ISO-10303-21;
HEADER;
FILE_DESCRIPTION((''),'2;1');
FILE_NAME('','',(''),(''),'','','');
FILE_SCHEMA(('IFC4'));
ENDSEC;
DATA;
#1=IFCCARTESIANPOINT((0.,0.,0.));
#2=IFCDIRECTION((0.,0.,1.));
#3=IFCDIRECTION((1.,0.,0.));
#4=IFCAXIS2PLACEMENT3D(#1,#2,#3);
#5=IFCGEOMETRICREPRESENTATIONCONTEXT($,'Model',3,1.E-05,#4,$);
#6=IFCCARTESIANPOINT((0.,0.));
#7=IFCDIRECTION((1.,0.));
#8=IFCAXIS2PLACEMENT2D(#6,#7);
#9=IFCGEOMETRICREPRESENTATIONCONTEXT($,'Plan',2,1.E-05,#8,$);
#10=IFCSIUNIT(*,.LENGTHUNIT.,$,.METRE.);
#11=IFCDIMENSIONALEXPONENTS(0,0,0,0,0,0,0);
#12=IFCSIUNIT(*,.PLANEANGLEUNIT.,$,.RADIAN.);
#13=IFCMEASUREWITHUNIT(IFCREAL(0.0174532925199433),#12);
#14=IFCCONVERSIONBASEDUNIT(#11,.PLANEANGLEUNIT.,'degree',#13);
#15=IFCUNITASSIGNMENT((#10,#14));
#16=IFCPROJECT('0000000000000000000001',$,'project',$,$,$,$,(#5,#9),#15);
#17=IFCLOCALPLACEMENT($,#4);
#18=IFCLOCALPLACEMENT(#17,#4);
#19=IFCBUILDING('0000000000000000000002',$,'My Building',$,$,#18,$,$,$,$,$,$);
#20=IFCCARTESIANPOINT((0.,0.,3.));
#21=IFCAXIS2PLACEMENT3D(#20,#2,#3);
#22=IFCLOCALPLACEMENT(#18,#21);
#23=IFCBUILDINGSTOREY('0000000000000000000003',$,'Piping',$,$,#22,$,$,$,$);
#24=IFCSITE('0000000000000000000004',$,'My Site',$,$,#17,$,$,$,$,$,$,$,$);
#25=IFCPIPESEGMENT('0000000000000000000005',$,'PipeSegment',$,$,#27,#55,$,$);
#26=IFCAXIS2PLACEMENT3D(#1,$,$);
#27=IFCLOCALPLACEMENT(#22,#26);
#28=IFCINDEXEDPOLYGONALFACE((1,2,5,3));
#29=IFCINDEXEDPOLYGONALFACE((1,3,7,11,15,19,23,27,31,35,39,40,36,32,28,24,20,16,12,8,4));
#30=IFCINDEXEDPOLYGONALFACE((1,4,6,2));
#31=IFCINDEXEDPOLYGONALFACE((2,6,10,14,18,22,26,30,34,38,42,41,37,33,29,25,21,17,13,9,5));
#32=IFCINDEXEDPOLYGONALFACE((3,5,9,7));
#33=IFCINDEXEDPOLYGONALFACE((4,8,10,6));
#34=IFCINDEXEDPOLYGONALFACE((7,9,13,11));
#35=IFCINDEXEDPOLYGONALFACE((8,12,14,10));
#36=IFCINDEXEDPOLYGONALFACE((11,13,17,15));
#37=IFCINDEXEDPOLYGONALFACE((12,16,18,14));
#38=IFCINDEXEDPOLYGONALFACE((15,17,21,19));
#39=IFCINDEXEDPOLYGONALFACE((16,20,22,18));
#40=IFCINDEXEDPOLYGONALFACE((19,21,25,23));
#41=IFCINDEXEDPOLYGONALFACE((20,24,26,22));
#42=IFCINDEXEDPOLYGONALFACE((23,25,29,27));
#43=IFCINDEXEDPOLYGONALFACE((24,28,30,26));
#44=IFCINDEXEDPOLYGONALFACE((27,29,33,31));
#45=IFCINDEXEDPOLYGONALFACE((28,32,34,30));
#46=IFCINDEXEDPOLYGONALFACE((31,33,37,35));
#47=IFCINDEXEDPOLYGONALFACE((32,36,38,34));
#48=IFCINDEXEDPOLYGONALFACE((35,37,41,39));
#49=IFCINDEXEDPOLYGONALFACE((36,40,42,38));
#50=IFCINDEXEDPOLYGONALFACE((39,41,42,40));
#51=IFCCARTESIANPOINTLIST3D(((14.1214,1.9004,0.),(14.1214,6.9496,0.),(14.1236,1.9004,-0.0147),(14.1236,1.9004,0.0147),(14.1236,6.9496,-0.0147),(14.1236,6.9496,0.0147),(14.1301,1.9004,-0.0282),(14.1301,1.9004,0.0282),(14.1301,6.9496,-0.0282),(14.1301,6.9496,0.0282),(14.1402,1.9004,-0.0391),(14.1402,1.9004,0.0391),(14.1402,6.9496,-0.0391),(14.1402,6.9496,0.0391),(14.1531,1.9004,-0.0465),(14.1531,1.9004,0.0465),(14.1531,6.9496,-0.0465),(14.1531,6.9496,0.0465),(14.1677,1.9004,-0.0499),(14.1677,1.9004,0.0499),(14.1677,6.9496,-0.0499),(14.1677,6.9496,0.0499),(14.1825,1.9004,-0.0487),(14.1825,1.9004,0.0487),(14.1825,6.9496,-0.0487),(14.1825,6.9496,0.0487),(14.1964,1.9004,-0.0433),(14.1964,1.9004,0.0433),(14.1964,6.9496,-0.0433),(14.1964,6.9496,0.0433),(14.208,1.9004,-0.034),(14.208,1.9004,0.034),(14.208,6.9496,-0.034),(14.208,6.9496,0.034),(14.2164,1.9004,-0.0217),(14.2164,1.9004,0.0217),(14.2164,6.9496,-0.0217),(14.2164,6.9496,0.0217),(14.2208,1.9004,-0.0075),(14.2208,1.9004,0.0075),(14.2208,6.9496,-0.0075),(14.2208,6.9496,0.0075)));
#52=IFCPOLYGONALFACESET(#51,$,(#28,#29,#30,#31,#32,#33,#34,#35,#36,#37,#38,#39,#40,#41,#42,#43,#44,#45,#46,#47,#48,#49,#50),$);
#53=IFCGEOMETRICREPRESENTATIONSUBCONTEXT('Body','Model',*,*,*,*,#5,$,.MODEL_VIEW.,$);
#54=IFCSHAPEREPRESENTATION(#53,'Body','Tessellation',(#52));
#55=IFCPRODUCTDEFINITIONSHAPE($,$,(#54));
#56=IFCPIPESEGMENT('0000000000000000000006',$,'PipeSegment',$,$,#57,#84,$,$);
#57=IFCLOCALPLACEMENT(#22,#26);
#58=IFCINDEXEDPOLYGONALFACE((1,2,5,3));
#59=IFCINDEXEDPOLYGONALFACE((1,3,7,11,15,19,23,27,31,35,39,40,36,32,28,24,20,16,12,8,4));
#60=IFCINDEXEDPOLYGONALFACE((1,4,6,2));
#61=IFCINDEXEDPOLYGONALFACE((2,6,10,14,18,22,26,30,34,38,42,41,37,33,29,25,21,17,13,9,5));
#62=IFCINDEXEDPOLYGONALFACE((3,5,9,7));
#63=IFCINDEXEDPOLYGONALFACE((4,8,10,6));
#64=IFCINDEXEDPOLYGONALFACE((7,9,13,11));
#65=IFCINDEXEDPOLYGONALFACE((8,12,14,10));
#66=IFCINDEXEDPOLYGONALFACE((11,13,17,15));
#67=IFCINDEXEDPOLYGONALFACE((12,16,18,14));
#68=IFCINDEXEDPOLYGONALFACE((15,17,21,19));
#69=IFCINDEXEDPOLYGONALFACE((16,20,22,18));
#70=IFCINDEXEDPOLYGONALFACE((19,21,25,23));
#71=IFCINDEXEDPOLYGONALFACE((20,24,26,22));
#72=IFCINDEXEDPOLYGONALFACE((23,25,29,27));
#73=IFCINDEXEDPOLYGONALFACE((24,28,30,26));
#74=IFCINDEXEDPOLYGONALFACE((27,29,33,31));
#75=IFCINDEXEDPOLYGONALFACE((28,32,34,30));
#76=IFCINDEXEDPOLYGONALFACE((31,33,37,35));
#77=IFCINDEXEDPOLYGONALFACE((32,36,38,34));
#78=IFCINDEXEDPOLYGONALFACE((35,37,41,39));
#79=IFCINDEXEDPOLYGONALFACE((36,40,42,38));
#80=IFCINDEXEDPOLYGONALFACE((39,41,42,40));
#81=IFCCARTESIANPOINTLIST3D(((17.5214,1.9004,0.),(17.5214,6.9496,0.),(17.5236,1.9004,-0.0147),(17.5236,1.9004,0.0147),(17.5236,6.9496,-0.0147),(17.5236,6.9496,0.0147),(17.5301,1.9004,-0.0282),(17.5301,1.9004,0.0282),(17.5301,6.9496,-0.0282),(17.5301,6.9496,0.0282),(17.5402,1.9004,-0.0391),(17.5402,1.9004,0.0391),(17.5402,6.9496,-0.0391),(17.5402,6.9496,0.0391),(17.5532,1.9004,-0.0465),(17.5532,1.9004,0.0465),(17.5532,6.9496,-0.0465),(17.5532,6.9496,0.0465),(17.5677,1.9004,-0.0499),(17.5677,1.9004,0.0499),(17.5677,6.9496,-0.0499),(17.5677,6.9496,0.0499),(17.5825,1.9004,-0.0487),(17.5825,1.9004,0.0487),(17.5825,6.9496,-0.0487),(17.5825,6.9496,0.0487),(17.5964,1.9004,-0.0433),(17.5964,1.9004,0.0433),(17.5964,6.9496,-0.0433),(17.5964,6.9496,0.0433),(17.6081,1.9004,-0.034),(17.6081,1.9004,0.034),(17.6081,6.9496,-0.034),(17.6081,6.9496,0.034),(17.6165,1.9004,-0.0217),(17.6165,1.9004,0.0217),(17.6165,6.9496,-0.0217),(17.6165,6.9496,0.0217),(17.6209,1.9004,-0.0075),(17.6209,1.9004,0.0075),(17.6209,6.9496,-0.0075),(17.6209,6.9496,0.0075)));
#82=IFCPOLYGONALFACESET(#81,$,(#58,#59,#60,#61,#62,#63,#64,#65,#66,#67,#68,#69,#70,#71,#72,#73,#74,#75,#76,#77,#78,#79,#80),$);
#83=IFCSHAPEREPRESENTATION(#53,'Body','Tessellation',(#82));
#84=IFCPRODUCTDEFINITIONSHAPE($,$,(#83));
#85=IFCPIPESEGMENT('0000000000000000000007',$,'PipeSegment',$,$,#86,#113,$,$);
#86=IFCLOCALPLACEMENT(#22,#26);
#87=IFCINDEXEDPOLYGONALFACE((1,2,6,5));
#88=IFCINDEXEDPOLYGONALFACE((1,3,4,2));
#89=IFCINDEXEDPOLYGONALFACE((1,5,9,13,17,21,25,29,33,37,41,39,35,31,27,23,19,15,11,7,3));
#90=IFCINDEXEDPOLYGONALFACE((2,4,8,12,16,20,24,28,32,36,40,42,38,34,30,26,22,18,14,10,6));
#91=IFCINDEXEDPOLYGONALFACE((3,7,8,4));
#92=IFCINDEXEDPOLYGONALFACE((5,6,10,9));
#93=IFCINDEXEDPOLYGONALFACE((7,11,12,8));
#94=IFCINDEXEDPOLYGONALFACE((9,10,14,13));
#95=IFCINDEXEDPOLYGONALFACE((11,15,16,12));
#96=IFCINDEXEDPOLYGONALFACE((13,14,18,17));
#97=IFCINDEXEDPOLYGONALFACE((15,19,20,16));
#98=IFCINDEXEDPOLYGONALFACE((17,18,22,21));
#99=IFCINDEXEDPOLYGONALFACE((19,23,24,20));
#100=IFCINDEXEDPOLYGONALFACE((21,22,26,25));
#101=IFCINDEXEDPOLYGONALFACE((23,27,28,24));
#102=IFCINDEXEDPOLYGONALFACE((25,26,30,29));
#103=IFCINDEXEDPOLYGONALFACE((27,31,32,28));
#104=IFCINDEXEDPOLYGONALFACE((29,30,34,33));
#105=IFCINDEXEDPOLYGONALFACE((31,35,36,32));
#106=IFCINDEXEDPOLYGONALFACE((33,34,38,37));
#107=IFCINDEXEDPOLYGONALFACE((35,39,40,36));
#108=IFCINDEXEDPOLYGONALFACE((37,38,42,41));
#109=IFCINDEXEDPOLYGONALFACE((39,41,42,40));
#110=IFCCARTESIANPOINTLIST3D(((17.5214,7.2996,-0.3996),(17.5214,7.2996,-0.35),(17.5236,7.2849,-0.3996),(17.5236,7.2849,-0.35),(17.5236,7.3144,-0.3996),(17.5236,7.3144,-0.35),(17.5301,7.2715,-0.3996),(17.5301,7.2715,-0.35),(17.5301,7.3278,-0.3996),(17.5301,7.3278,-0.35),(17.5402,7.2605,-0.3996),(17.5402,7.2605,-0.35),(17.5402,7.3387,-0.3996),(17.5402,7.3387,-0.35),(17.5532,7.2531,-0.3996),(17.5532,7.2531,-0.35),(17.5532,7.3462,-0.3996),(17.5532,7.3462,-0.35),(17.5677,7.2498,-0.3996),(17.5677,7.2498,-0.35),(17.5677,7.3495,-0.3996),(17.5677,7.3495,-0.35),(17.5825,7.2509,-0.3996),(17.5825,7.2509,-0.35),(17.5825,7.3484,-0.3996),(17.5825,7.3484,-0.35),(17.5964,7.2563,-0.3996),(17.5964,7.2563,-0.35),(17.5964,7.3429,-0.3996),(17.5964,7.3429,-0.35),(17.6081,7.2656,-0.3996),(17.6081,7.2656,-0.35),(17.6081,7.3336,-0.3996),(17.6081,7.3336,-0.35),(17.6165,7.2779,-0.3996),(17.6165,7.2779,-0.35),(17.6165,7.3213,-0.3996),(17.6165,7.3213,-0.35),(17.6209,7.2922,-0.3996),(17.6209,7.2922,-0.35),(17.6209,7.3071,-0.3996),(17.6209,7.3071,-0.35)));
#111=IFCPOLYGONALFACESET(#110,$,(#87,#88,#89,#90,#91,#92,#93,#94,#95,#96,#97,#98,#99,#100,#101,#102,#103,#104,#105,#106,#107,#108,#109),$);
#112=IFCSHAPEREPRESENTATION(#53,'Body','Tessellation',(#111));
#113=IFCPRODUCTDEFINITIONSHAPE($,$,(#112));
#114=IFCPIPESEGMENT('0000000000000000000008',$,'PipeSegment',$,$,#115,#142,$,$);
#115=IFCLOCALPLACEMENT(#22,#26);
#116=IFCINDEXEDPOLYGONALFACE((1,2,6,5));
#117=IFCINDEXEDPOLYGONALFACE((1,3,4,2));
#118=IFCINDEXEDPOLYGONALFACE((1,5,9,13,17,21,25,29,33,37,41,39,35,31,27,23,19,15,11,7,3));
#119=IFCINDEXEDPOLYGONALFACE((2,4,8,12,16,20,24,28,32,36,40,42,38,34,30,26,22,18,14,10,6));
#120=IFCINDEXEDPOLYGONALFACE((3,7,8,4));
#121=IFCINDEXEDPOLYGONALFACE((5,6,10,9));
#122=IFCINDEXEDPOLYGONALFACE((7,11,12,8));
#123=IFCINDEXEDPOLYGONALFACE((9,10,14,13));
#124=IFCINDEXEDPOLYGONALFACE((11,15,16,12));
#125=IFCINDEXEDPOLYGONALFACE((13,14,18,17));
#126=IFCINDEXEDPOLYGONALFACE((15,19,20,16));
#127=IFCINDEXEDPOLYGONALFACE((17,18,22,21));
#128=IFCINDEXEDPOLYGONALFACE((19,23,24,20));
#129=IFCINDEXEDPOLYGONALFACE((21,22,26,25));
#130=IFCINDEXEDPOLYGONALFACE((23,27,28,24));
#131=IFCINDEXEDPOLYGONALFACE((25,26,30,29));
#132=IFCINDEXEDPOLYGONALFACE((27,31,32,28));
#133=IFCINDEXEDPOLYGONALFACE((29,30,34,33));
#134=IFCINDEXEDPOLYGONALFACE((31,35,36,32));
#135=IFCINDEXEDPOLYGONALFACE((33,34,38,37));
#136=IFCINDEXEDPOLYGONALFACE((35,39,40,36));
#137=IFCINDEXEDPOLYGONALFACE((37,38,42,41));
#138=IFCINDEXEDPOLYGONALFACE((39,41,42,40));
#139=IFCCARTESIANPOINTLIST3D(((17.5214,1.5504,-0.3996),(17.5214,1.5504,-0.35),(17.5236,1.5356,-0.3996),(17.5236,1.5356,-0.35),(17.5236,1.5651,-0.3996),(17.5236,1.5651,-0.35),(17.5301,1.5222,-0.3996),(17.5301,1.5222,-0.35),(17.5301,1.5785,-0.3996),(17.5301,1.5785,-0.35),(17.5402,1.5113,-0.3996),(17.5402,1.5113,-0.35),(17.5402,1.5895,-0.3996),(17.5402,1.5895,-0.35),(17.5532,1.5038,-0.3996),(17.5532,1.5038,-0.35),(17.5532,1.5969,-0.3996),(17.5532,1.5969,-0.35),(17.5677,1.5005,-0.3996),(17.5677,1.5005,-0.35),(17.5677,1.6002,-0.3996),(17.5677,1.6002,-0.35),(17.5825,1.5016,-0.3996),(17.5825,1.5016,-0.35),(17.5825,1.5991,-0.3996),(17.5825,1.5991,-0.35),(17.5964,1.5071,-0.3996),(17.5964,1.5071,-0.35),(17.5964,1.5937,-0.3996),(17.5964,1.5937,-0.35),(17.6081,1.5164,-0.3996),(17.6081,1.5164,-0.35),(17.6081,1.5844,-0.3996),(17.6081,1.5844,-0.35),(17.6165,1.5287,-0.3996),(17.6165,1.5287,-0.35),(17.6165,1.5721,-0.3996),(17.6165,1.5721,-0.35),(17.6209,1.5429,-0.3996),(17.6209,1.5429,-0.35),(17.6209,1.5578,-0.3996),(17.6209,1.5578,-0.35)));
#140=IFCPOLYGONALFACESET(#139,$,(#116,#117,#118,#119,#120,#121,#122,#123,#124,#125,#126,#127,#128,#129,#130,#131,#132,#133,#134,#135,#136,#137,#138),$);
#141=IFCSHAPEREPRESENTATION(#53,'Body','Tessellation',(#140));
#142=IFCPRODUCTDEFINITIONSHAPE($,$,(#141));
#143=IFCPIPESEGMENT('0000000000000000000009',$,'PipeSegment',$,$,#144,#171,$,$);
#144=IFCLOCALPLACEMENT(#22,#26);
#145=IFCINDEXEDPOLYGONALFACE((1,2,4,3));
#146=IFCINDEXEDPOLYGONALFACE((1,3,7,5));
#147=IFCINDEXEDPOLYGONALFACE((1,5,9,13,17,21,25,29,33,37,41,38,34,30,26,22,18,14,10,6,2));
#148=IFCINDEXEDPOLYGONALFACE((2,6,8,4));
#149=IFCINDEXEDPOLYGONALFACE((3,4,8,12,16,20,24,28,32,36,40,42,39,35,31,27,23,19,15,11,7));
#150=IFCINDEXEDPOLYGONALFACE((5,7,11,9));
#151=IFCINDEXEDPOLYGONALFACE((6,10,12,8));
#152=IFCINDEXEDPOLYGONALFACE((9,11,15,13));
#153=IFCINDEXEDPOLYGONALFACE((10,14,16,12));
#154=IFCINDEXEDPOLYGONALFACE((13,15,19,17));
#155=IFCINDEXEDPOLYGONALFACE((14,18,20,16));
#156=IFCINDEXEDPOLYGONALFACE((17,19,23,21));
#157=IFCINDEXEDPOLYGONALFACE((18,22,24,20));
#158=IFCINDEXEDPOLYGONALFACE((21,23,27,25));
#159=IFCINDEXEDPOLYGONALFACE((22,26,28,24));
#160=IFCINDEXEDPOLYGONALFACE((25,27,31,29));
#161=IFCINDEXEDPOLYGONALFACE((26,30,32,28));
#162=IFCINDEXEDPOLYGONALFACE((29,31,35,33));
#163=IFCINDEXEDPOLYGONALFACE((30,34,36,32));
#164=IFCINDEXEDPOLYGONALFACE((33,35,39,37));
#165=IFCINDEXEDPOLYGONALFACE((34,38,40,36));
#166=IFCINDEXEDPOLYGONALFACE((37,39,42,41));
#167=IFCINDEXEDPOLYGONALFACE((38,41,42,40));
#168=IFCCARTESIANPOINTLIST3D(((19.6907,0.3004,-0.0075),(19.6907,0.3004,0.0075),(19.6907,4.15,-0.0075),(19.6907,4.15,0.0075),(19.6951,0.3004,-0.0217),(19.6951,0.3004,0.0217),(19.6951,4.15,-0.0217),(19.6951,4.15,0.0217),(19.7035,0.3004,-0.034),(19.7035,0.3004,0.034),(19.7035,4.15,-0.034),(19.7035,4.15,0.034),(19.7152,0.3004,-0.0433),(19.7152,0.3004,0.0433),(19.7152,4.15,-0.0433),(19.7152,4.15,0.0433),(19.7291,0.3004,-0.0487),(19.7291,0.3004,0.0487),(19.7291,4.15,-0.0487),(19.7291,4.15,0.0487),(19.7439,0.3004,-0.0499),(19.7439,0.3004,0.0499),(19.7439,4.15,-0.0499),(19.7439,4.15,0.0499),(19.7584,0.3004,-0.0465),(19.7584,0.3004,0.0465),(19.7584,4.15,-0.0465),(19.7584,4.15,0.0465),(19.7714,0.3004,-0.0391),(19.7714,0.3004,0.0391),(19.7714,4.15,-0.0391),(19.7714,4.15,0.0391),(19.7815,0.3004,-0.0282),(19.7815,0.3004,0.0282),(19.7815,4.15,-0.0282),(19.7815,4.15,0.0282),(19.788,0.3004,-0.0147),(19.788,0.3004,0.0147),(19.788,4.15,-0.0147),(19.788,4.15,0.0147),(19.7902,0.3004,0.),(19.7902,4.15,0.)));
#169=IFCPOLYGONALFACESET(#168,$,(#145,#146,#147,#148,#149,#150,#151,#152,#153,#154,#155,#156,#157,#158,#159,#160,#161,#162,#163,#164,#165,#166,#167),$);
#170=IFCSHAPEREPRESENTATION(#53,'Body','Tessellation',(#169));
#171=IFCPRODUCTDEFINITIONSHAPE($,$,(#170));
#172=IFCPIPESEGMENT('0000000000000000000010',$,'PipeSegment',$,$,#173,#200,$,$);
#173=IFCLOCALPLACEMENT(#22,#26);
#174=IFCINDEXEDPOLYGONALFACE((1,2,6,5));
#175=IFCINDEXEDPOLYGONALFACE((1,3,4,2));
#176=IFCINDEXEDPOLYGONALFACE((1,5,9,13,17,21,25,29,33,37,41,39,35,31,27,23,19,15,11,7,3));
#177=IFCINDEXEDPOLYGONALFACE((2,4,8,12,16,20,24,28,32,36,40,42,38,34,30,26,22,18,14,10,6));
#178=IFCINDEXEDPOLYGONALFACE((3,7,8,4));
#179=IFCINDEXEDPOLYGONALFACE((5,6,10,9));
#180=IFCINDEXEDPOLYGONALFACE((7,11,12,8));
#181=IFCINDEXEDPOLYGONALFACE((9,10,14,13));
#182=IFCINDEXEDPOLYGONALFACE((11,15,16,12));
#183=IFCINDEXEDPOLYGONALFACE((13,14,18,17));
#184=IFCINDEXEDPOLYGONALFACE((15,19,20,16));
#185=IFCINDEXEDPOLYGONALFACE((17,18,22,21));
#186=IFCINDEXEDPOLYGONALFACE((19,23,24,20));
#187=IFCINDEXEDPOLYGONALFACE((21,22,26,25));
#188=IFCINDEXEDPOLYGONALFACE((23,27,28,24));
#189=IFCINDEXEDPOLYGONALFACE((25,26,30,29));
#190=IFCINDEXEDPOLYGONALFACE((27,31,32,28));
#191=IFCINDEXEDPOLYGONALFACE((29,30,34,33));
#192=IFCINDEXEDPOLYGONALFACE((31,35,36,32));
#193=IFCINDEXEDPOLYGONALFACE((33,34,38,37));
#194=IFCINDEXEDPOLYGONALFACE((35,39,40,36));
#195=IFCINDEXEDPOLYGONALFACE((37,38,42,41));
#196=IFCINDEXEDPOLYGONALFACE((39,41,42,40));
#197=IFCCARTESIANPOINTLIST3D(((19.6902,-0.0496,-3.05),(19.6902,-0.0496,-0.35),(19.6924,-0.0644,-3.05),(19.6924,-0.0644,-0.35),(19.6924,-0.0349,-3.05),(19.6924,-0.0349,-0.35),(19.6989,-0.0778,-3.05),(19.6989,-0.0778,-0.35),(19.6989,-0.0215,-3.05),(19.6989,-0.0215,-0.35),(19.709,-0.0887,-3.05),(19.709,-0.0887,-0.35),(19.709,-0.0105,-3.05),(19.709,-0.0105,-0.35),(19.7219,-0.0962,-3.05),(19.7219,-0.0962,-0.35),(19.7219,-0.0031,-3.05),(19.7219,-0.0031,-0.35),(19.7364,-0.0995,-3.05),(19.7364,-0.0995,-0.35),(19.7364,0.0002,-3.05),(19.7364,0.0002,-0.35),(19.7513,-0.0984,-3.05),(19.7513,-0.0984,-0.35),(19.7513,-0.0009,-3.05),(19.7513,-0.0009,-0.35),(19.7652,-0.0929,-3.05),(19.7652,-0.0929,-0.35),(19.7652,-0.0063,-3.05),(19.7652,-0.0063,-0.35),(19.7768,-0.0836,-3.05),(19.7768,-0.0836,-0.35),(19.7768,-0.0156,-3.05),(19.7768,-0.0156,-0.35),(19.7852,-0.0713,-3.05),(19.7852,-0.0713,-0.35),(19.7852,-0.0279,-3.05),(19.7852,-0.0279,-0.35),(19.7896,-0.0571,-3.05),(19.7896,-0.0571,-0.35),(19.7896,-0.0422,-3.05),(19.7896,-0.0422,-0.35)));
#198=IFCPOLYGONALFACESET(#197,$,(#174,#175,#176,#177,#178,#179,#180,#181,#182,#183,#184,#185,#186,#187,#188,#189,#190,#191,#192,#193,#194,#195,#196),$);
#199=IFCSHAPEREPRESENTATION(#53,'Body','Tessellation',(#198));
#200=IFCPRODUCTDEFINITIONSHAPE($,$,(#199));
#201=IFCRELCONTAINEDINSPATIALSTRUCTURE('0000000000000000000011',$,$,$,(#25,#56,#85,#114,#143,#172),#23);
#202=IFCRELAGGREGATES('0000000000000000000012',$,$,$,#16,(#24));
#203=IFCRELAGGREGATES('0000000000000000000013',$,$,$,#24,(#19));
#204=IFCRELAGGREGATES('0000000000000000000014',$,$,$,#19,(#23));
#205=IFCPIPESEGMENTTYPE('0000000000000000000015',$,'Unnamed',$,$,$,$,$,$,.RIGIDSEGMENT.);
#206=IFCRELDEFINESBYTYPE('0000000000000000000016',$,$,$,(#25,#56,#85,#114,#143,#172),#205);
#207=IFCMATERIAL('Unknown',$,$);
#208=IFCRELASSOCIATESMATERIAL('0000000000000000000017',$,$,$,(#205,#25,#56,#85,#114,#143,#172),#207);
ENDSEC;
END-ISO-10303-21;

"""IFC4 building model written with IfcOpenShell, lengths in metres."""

from ifc_helpers import new_model, entity, si_unit, converted_unit, frame, origin_with_axes, origin_2d_with_axis, place, context, subcontext, project, spatial, circle, extrude, material, material_profile, profile_set, profile_usage, type_object, element, save


model = new_model("IFC4")

# Units and contexts
model_context = context("Model", 3, precision=1e-05, world=origin_with_axes())
plan_context = context("Plan", 2, precision=1e-05, world=origin_2d_with_axis())
body_context = subcontext(model_context, "Body", "Model", "MODEL_VIEW")
ifc_project = project(units=[si_unit("LENGTHUNIT", "METRE"), converted_unit("PLANEANGLEUNIT", "degree", entity("IfcReal", 0.0174532925199433), si_unit("PLANEANGLEUNIT", "RADIAN"), dimensions=[0, 0, 0, 0, 0, 0, 0])], contexts=[model_context, plan_context])

# Site, building, storey
site_placement = place(None, origin_with_axes())
site = spatial("IfcSite", under=ifc_project, at=site_placement, Name="My Site")
building_placement = place(site_placement, origin_with_axes())
building = spatial("IfcBuilding", under=site, at=building_placement, Name="My Building")
storey_placement = place(building_placement, frame((0.0, 0.0, 3.0), z_axis=(0.0, 0.0, 1.0), x_axis=(1.0, 0.0, 0.0)))
storey = spatial("IfcBuildingStorey", under=building, at=storey_placement, Name="Piping")

# Pipe segments
ifc_material = material(Name="Unknown")
ifc_material_profile = material_profile(ifc_material, circle(Radius=0.05))
ifc_profile_set = profile_set([ifc_material_profile])
pipe_segment_type = type_object("IfcPipeSegmentType", Name="Unnamed", PredefinedType="RIGIDSEGMENT", material=ifc_profile_set)
ifc_profile_usage_1 = profile_usage(ifc_profile_set, cardinal=5)
pipe_segment_1_placement = place(storey_placement, frame((14.1714, 1.9004, 0.0), z_axis=(0.0, 1.0, 0.0), x_axis=(-1.0, 0.0, 0.0)))
element("IfcPipeSegment", 1, at=pipe_segment_1_placement, inside=storey, type_object=pipe_segment_type, material=ifc_profile_usage_1, Name="PipeSegment", context=body_context, shape_type="SweptSolid", body=[
    extrude(circle(Radius=0.05), origin_with_axes(), (0.0, 0.0, 1.0), 5.0493),
])
ifc_profile_usage_2 = profile_usage(ifc_profile_set, cardinal=5)
pipe_segment_2_placement = place(storey_placement, frame((17.5714, 1.9004, 0.0), z_axis=(0.0, 1.0, 0.0), x_axis=(-1.0, 0.0, 0.0)))
element("IfcPipeSegment", 2, at=pipe_segment_2_placement, inside=storey, type_object=pipe_segment_type, material=ifc_profile_usage_2, Name="PipeSegment", context=body_context, shape_type="SweptSolid", body=[
    extrude(circle(Radius=0.05), origin_with_axes(), (0.0, 0.0, 1.0), 5.0493),
])
ifc_profile_usage_3 = profile_usage(ifc_profile_set, cardinal=5)
pipe_segment_3_placement = place(storey_placement, frame((17.5714, 7.2996, -0.35), z_axis=(0.0, 0.0, -1.0), x_axis=(-1.0, 0.0, 0.0)))
element("IfcPipeSegment", 3, at=pipe_segment_3_placement, inside=storey, type_object=pipe_segment_type, material=ifc_profile_usage_3, Name="PipeSegment", context=body_context, shape_type="SweptSolid", body=[
    extrude(circle(Radius=0.05), origin_with_axes(), (0.0, 0.0, 1.0), 0.0496),
])
ifc_profile_usage_4 = profile_usage(ifc_profile_set, cardinal=5)
pipe_segment_4_placement = place(storey_placement, frame((17.5714, 1.5504, -0.35), z_axis=(0.0, 0.0, -1.0), x_axis=(-1.0, 0.0, 0.0)))
element("IfcPipeSegment", 4, at=pipe_segment_4_placement, inside=storey, type_object=pipe_segment_type, material=ifc_profile_usage_4, Name="PipeSegment", context=body_context, shape_type="SweptSolid", body=[
    extrude(circle(Radius=0.05), origin_with_axes(), (0.0, 0.0, 1.0), 0.0496),
])
ifc_profile_usage_5 = profile_usage(ifc_profile_set, cardinal=5)
pipe_segment_5_placement = place(storey_placement, frame((19.7402, 4.15, 0.0), z_axis=(0.0, -1.0, 0.0), x_axis=(1.0, 0.0, 0.0)))
element("IfcPipeSegment", 5, at=pipe_segment_5_placement, inside=storey, type_object=pipe_segment_type, material=ifc_profile_usage_5, Name="PipeSegment", context=body_context, shape_type="SweptSolid", body=[
    extrude(circle(Radius=0.05), origin_with_axes(), (0.0, 0.0, 1.0), 3.8496),
])
ifc_profile_usage_6 = profile_usage(ifc_profile_set, cardinal=5)
pipe_segment_6_placement = place(storey_placement, frame((19.7402, -0.0496, -0.35), z_axis=(0.0, 0.0, -1.0), x_axis=(-1.0, 0.0, 0.0)))
element("IfcPipeSegment", 6, at=pipe_segment_6_placement, inside=storey, type_object=pipe_segment_type, material=ifc_profile_usage_6, Name="PipeSegment", context=body_context, shape_type="SweptSolid", body=[
    extrude(circle(Radius=0.05), origin_with_axes(), (0.0, 0.0, 1.0), 2.7),
])

save(model, "model.ifc")
